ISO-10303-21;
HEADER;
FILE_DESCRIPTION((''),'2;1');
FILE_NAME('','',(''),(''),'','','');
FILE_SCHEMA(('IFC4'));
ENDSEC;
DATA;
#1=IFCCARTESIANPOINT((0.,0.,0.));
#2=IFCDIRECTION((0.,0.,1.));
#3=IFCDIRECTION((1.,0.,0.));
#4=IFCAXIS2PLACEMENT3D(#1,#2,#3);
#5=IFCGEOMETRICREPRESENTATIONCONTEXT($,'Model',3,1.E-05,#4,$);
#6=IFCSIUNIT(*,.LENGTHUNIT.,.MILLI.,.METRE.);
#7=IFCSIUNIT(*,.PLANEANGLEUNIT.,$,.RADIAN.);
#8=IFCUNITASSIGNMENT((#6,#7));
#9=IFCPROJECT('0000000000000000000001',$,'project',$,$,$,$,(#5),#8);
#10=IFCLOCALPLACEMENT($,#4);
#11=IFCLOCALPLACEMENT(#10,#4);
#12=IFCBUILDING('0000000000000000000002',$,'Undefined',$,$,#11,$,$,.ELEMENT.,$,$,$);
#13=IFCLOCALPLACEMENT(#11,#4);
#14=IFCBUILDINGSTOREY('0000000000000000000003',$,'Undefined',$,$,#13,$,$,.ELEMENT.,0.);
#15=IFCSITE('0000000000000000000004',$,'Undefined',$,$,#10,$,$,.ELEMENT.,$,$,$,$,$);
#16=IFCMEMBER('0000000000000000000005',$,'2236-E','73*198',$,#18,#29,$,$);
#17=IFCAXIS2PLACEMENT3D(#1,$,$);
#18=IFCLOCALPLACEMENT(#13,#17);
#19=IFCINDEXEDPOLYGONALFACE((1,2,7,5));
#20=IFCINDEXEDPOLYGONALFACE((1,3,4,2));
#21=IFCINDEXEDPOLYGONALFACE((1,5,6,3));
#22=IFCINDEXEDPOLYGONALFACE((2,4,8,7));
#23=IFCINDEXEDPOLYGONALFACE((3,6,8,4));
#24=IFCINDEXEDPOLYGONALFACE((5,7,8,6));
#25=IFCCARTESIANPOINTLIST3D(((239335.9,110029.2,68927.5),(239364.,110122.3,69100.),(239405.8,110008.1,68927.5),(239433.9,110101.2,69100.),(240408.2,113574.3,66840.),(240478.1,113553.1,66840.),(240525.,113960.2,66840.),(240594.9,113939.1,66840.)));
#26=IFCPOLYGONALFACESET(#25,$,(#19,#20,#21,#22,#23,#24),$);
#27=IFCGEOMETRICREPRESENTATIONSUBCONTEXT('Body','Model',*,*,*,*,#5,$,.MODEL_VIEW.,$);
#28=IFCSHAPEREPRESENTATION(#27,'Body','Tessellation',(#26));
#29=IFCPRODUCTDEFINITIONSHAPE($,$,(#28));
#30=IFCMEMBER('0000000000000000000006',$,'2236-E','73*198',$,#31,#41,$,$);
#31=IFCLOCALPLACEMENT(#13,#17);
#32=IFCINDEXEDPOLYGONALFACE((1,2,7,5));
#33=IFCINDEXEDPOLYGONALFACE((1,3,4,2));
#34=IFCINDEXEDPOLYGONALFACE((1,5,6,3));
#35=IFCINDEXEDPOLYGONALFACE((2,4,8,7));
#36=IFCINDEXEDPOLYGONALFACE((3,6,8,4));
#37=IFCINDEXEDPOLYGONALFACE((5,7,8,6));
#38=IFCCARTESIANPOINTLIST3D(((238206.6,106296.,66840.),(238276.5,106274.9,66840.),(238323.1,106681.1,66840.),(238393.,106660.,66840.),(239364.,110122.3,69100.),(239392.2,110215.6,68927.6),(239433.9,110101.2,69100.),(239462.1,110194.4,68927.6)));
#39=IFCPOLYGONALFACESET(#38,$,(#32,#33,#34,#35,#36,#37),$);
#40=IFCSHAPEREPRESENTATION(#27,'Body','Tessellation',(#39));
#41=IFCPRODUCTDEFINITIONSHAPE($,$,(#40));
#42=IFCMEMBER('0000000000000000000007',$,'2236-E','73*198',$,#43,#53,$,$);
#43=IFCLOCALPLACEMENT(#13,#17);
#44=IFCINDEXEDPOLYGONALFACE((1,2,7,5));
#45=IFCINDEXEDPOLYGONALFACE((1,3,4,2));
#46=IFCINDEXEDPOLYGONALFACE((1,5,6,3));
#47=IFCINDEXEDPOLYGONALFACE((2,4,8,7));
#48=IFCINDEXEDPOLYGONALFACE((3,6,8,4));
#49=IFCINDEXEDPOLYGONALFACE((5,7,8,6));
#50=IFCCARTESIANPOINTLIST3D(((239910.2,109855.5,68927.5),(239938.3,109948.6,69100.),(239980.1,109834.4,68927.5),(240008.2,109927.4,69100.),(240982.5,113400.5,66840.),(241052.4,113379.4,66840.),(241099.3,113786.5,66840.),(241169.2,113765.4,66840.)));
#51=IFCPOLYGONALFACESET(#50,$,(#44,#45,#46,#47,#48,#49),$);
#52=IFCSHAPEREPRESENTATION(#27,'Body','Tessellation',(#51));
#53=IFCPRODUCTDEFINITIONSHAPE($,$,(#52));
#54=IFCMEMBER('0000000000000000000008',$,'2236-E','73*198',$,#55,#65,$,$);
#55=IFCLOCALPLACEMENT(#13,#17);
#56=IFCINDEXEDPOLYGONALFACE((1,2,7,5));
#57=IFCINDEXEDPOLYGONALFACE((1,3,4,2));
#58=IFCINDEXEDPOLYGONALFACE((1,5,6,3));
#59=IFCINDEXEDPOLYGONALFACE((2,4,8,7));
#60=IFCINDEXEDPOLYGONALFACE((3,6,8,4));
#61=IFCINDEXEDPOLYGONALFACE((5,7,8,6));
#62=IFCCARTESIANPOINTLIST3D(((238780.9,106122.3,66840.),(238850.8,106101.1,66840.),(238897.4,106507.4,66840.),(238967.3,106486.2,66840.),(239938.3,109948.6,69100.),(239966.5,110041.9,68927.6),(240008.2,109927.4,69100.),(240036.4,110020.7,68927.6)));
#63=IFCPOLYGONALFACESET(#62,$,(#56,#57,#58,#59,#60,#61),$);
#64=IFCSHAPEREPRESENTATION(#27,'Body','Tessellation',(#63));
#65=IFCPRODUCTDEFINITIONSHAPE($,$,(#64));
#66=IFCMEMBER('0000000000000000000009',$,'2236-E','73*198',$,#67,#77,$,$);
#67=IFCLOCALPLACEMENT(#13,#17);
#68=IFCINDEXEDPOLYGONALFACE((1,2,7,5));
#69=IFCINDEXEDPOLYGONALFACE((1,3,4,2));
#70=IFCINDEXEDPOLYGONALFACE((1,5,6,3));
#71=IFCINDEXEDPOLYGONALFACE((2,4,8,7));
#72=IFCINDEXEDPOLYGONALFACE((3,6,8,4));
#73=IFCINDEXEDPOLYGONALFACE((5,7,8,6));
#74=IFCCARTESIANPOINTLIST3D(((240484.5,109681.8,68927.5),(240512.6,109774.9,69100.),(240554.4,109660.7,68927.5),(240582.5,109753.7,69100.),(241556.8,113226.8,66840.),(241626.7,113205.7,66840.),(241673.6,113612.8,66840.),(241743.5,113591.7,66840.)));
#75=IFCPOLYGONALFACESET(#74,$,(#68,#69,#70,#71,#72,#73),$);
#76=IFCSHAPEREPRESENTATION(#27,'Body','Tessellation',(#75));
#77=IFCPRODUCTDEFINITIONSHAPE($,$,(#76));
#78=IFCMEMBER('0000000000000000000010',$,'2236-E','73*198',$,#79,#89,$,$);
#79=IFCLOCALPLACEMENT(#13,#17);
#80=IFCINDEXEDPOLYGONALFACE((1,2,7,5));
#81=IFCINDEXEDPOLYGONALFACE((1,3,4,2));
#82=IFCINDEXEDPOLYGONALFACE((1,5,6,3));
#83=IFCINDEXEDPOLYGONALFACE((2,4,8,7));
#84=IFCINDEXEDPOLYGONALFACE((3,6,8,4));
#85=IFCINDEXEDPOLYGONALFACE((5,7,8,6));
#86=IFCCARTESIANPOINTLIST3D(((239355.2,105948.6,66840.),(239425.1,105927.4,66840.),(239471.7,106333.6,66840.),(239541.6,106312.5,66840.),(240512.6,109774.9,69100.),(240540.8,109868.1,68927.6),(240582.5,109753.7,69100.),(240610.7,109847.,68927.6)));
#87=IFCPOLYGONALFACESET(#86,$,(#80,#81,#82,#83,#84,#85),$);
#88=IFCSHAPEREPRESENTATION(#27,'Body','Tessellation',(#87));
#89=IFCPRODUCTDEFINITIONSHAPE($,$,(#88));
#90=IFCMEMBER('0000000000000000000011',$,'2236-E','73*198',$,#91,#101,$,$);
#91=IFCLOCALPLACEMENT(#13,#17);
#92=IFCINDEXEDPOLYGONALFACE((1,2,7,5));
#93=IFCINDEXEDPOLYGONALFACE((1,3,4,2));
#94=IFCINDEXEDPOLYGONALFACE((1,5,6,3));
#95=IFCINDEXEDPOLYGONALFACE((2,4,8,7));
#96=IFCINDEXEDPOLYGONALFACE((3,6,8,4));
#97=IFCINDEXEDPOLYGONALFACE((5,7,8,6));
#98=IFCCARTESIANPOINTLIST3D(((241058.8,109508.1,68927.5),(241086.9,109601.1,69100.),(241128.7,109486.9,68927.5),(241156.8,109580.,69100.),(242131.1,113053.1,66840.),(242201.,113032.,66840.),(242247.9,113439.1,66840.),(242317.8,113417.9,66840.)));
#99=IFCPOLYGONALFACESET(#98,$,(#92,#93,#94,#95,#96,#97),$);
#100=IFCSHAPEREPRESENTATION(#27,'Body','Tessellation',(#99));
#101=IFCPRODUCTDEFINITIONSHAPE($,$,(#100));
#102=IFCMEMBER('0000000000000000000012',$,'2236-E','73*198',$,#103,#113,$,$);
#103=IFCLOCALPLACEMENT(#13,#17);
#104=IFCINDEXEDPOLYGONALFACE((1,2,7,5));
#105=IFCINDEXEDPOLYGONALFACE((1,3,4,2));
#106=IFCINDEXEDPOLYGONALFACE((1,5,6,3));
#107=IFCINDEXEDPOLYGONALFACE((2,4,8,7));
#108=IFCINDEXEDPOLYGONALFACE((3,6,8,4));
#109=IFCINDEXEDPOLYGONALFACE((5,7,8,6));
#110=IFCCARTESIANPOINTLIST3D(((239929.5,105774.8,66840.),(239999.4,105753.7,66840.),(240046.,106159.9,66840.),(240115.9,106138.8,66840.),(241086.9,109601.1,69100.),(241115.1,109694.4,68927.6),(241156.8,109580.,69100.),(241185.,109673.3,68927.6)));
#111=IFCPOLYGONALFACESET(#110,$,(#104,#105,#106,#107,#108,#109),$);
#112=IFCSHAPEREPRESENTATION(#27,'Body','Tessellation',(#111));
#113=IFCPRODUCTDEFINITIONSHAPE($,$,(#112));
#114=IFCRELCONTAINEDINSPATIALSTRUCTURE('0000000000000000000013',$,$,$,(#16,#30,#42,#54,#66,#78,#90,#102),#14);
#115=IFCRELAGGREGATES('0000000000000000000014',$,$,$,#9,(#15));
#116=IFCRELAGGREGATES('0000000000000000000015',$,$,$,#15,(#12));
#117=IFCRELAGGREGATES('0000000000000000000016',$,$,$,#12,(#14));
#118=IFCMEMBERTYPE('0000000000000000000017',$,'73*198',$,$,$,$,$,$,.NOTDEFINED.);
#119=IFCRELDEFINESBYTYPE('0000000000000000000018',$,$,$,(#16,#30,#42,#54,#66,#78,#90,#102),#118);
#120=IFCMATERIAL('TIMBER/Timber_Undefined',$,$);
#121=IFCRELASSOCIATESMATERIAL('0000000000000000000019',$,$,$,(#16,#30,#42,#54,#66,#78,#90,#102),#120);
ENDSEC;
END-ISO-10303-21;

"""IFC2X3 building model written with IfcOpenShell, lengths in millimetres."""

from ifc_helpers import new_model, si_unit, frame, origin_with_axes, origin_2d_with_axis, place, context, subcontext, project, spatial, rectangle, extrude, clip, halfspace, material, type_object, element, save


model = new_model("IFC2X3")

# Units and contexts
model_context = context("Model", 3, precision=1e-05, world=origin_with_axes())
body_context = subcontext(model_context, "Body", "Model", "MODEL_VIEW")
ifc_project = project(units=[si_unit("LENGTHUNIT", "METRE", prefix="MILLI"), si_unit("PLANEANGLEUNIT", "RADIAN")], contexts=[model_context])

# Site, building, storey
site_placement = place(None, origin_with_axes())
site = spatial("IfcSite", under=ifc_project, at=site_placement, Name="Undefined", CompositionType="ELEMENT")
building_placement = place(site_placement, origin_with_axes())
building = spatial("IfcBuilding", under=site, at=building_placement, Name="Undefined", CompositionType="ELEMENT")
storey_placement = place(building_placement, origin_with_axes())
storey = spatial("IfcBuildingStorey", under=building, at=storey_placement, Name="Undefined", CompositionType="ELEMENT", Elevation=0.0)

# Shared definitions
ifc_material = material(Name="TIMBER/Timber_Undefined")

# Members
member_type = type_object("IfcMemberType", Name="73*198", PredefinedType="NOTDEFINED")
member_1_placement = place(storey_placement, frame((239384.9, 110065.2, 69013.8), z_axis=(-0.957167, 0.289538, 0.0), x_axis=(0.252232, 0.833838, -0.491013)))
element("IfcMember", 1, at=member_1_placement, inside=storey, type_object=member_type, material=ifc_material, Name="2236-E", Description="73*198", context=body_context, shape_type="Clipping", body=[
    clip(extrude(rectangle(XDim=198.0, YDim=73.0, at=origin_2d_with_axis()), frame((9470.2, 0.0, 0.0), z_axis=(-1.0, 0.0, 0.0), x_axis=(0.0, -1.0, 0.0)), (0.0, 0.0, 1.0), 9470.2), halfspace(frame((4746.2, -179.9, -36.5), z_axis=(0.491013, 0.871152, 0.0), x_axis=(0.0, 0.0, 1.0)), False)),
])
member_2_placement = place(storey_placement, frame((239413.1, 110158.4, 69013.8), z_axis=(-0.957167, 0.289538, 0.0), x_axis=(-0.252047, -0.833226, -0.492144)))
element("IfcMember", 2, at=member_2_placement, inside=storey, type_object=member_type, material=ifc_material, Name="2236-E", Description="73*198", context=body_context, shape_type="Clipping", body=[
    clip(extrude(rectangle(XDim=198.0, YDim=73.0, at=origin_2d_with_axis()), frame((9448.4, 0.0, 0.0), z_axis=(-1.0, 0.0, 0.0), x_axis=(0.0, -1.0, 0.0)), (0.0, 0.0, 1.0), 9448.5), halfspace(frame((4746.1, 186.1, 36.5), z_axis=(0.492144, -0.870514, 0.0), x_axis=(0.0, 0.0, -1.0)), False)),
])
member_3_placement = place(storey_placement, frame((239959.2, 109891.5, 69013.8), z_axis=(-0.957167, 0.289538, 0.0), x_axis=(0.252232, 0.833838, -0.491013)))
element("IfcMember", 3, at=member_3_placement, inside=storey, type_object=member_type, material=ifc_material, Name="2236-E", Description="73*198", context=body_context, shape_type="Clipping", body=[
    clip(extrude(rectangle(XDim=198.0, YDim=73.0, at=origin_2d_with_axis()), frame((9470.2, 0.0, 0.0), z_axis=(-1.0, 0.0, 0.0), x_axis=(0.0, -1.0, 0.0)), (0.0, 0.0, 1.0), 9470.2), halfspace(frame((4746.2, -179.9, -36.5), z_axis=(0.491013, 0.871152, 0.0), x_axis=(0.0, 0.0, 1.0)), False)),
])
member_4_placement = place(storey_placement, frame((239987.4, 109984.6, 69013.8), z_axis=(-0.957167, 0.289538, 0.0), x_axis=(-0.252047, -0.833226, -0.492144)))
element("IfcMember", 4, at=member_4_placement, inside=storey, type_object=member_type, material=ifc_material, Name="2236-E", Description="73*198", context=body_context, shape_type="Clipping", body=[
    clip(extrude(rectangle(XDim=198.0, YDim=73.0, at=origin_2d_with_axis()), frame((9448.4, 0.0, 0.0), z_axis=(-1.0, 0.0, 0.0), x_axis=(0.0, -1.0, 0.0)), (0.0, 0.0, 1.0), 9448.5), halfspace(frame((4746.1, 186.1, 36.5), z_axis=(0.492144, -0.870514, 0.0), x_axis=(0.0, 0.0, -1.0)), False)),
])
member_5_placement = place(storey_placement, frame((240533.5, 109717.8, 69013.8), z_axis=(-0.957167, 0.289538, 0.0), x_axis=(0.252232, 0.833838, -0.491013)))
element("IfcMember", 5, at=member_5_placement, inside=storey, type_object=member_type, material=ifc_material, Name="2236-E", Description="73*198", context=body_context, shape_type="Clipping", body=[
    clip(extrude(rectangle(XDim=198.0, YDim=73.0, at=origin_2d_with_axis()), frame((9470.2, 0.0, 0.0), z_axis=(-1.0, 0.0, 0.0), x_axis=(0.0, -1.0, 0.0)), (0.0, 0.0, 1.0), 9470.2), halfspace(frame((4746.2, -179.9, -36.5), z_axis=(0.491013, 0.871152, 0.0), x_axis=(0.0, 0.0, 1.0)), False)),
])
member_6_placement = place(storey_placement, frame((240561.7, 109810.9, 69013.8), z_axis=(-0.957167, 0.289538, 0.0), x_axis=(-0.252047, -0.833226, -0.492144)))
element("IfcMember", 6, at=member_6_placement, inside=storey, type_object=member_type, material=ifc_material, Name="2236-E", Description="73*198", context=body_context, shape_type="Clipping", body=[
    clip(extrude(rectangle(XDim=198.0, YDim=73.0, at=origin_2d_with_axis()), frame((9448.4, 0.0, 0.0), z_axis=(-1.0, 0.0, 0.0), x_axis=(0.0, -1.0, 0.0)), (0.0, 0.0, 1.0), 9448.5), halfspace(frame((4746.1, 186.1, 36.5), z_axis=(0.492144, -0.870514, 0.0), x_axis=(0.0, 0.0, -1.0)), False)),
])
member_7_placement = place(storey_placement, frame((241107.8, 109544.0, 69013.8), z_axis=(-0.957167, 0.289538, 0.0), x_axis=(0.252232, 0.833838, -0.491013)))
element("IfcMember", 7, at=member_7_placement, inside=storey, type_object=member_type, material=ifc_material, Name="2236-E", Description="73*198", context=body_context, shape_type="Clipping", body=[
    clip(extrude(rectangle(XDim=198.0, YDim=73.0, at=origin_2d_with_axis()), frame((9470.2, 0.0, 0.0), z_axis=(-1.0, 0.0, 0.0), x_axis=(0.0, -1.0, 0.0)), (0.0, 0.0, 1.0), 9470.2), halfspace(frame((4746.2, -179.9, -36.5), z_axis=(0.491013, 0.871152, 0.0), x_axis=(0.0, 0.0, 1.0)), False)),
])
member_8_placement = place(storey_placement, frame((241136.0, 109637.2, 69013.8), z_axis=(-0.957167, 0.289538, 0.0), x_axis=(-0.252047, -0.833226, -0.492144)))
element("IfcMember", 8, at=member_8_placement, inside=storey, type_object=member_type, material=ifc_material, Name="2236-E", Description="73*198", context=body_context, shape_type="Clipping", body=[
    clip(extrude(rectangle(XDim=198.0, YDim=73.0, at=origin_2d_with_axis()), frame((9448.4, 0.0, 0.0), z_axis=(-1.0, 0.0, 0.0), x_axis=(0.0, -1.0, 0.0)), (0.0, 0.0, 1.0), 9448.5), halfspace(frame((4746.1, 186.1, 36.5), z_axis=(0.492144, -0.870514, 0.0), x_axis=(0.0, 0.0, -1.0)), False)),
])

save(model, "model.ifc")
